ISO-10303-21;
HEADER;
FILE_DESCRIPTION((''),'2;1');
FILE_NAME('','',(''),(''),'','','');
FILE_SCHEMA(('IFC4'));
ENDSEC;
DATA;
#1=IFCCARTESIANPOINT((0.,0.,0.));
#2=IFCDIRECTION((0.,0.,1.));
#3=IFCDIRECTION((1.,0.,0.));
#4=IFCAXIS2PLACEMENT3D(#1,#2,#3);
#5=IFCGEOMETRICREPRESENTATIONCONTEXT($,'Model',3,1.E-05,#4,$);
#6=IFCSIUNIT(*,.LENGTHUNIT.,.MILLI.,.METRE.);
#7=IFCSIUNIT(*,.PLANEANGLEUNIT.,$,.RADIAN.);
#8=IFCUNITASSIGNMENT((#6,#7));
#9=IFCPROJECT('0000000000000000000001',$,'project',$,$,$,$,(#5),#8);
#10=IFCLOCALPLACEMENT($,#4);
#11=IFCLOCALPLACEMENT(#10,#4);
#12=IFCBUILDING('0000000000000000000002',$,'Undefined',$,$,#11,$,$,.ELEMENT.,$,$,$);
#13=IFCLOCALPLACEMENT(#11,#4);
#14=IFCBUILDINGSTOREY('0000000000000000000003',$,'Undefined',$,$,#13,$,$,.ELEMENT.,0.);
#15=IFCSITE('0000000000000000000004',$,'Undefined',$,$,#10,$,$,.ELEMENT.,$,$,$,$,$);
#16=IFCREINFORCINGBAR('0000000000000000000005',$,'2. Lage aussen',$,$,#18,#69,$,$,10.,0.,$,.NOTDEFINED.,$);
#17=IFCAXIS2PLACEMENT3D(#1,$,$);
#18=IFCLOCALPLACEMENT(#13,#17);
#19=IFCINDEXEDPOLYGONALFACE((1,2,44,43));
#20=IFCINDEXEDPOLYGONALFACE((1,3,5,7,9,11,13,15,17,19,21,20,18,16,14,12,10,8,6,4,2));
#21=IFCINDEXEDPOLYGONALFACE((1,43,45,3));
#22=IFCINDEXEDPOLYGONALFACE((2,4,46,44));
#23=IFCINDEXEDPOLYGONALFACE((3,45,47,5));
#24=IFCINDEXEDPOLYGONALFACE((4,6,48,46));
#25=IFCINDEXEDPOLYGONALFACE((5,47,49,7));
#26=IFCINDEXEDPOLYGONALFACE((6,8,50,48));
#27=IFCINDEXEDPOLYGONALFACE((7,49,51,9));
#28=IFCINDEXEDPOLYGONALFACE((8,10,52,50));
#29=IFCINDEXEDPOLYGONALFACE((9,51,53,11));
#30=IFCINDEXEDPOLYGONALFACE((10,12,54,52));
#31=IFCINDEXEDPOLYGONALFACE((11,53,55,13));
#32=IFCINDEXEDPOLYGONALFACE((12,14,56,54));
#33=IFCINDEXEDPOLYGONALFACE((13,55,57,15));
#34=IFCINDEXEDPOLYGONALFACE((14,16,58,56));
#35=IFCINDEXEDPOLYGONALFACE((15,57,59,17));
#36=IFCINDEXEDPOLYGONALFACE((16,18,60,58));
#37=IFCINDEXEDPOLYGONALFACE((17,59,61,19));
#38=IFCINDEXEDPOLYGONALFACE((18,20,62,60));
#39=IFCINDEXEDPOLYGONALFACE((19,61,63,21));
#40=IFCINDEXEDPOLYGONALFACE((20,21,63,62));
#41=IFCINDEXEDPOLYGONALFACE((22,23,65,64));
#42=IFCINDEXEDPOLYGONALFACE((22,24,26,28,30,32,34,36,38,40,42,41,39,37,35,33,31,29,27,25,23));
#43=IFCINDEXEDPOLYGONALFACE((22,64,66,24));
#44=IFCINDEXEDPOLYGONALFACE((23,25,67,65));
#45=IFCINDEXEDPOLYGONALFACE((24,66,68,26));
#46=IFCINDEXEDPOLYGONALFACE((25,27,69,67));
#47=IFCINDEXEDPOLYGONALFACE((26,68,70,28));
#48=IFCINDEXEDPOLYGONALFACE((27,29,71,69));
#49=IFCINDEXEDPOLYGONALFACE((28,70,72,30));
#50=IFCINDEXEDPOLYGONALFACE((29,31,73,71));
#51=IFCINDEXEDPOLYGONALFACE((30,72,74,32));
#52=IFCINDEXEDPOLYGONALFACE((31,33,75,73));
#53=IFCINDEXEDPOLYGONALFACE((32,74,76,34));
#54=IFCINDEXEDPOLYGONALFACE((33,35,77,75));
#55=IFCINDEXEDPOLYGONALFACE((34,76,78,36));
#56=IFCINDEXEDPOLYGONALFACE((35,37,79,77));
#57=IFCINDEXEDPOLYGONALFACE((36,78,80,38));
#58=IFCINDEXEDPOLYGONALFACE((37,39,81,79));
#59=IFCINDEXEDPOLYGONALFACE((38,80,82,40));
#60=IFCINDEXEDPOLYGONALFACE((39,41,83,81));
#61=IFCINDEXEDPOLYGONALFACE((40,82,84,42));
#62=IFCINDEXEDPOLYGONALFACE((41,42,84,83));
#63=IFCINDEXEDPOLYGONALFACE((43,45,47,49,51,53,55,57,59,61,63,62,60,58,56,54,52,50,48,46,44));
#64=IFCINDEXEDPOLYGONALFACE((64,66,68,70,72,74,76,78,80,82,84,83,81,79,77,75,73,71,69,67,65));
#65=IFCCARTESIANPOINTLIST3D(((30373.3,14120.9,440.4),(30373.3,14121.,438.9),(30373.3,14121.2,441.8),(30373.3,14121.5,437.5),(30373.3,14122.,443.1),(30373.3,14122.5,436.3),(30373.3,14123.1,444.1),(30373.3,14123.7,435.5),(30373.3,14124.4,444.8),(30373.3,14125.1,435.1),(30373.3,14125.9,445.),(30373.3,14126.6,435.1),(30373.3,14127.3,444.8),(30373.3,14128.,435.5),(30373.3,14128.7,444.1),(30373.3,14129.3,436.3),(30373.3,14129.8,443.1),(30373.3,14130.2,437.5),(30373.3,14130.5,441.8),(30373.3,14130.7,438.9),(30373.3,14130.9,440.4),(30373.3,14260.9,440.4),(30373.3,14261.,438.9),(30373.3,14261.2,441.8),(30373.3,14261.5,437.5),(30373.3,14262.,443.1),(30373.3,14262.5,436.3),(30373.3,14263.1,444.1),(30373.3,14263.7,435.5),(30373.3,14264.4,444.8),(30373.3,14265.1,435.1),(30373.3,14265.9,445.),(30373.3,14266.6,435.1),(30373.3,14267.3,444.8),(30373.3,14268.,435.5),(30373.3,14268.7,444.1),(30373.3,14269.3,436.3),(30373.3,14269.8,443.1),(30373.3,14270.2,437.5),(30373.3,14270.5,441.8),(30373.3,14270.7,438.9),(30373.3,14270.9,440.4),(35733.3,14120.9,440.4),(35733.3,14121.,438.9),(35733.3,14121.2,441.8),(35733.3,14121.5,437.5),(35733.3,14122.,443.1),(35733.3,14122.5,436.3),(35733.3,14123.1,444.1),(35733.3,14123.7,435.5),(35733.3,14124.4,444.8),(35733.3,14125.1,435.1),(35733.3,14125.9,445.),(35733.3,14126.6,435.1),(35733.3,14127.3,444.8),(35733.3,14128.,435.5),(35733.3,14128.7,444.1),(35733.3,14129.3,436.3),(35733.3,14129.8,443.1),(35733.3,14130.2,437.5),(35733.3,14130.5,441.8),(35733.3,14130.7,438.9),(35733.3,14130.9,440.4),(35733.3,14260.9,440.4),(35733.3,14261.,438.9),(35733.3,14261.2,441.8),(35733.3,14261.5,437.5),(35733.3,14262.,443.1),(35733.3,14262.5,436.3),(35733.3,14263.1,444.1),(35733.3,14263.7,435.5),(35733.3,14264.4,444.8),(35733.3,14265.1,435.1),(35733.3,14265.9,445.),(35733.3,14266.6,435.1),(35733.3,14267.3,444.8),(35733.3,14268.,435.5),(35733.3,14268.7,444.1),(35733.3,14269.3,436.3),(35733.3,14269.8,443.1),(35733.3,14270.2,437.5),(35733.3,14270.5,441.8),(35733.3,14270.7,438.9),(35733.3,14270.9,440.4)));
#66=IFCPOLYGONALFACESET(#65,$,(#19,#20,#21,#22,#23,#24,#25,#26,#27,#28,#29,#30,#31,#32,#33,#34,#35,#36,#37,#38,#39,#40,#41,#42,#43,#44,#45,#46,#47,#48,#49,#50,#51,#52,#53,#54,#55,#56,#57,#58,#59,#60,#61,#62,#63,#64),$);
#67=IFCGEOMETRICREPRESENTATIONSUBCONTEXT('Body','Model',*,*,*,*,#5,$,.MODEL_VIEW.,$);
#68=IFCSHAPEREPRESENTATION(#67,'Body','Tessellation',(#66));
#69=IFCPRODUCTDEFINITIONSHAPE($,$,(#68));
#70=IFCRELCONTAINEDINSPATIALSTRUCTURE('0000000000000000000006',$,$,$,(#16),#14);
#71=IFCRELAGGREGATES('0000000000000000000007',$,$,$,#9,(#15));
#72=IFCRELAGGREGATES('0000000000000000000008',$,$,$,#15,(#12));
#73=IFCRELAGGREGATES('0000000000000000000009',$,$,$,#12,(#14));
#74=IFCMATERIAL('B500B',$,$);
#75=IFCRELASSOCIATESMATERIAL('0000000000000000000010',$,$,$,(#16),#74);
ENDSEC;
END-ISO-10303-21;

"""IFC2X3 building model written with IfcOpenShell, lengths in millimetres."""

from ifc_helpers import new_model, entity, si_unit, frame, origin_with_axes, place, context, subcontext, project, spatial, source, transform, mapped, material, element, save


model = new_model("IFC2X3")

# Units and contexts
model_context = context("Model", 3, precision=1e-05, world=origin_with_axes())
body_context = subcontext(model_context, "Body", "Model", "MODEL_VIEW")
ifc_project = project(units=[si_unit("LENGTHUNIT", "METRE", prefix="MILLI"), si_unit("PLANEANGLEUNIT", "RADIAN")], contexts=[model_context])

# Site, building, storey
site_placement = place(None, origin_with_axes())
site = spatial("IfcSite", under=ifc_project, at=site_placement, Name="Undefined", CompositionType="ELEMENT")
building_placement = place(site_placement, origin_with_axes())
building = spatial("IfcBuilding", under=site, at=building_placement, Name="Undefined", CompositionType="ELEMENT")
storey_placement = place(building_placement, origin_with_axes())
storey = spatial("IfcBuildingStorey", under=building, at=storey_placement, Name="Undefined", CompositionType="ELEMENT", Elevation=0.0)

# Reinforcing bar
ifc_material_1 = material(Name="B500B")
shared_shape_1 = source(origin_with_axes(), body_context, "Body", "AdvancedSweptSolid", [
    entity("IfcSweptDiskSolid", entity("IfcTrimmedCurve", entity("IfcLine", entity("IfcCartesianPoint", [0.0, 0.0, 0.0]), entity("IfcVector", entity("IfcDirection", [1.0, 0.0, 0.0]), 1.0)), [entity("IfcParameterValue", 0.0)], [entity("IfcParameterValue", 5360.0)], True, "PARAMETER"), 5.0, None, 0.0, 5360.0),
])
shared_shape_2 = source(origin_with_axes(), body_context, "Body", "AdvancedSweptSolid", [
    entity("IfcSweptDiskSolid", entity("IfcTrimmedCurve", entity("IfcLine", entity("IfcCartesianPoint", [0.0, 0.0, 0.0]), entity("IfcVector", entity("IfcDirection", [1.0, 0.0, 0.0]), 1.0)), [entity("IfcParameterValue", 0.0)], [entity("IfcParameterValue", 5360.0)], True, "PARAMETER"), 5.0, None, 0.0, 5360.0),
])
reinforcing_bar_1_placement = place(storey_placement, frame((35733.3, 14125.9, 440.0), z_axis=(0.0, 0.0, 1.0), x_axis=(-1.0, 0.0, 0.0)))
element("IfcReinforcingBar", 1, at=reinforcing_bar_1_placement, inside=storey, material=ifc_material_1, Name="2. Lage aussen", BarRole="NOTDEFINED", CrossSectionArea=0.0, NominalDiameter=10.0, context=body_context, shape_type="MappedRepresentation", body=[
    mapped(shared_shape_1, transform((0.0, 0.0, 0.0))),
    mapped(shared_shape_2, transform((0.0, -140.0, 0.0))),
])

save(model, "model.ifc")
